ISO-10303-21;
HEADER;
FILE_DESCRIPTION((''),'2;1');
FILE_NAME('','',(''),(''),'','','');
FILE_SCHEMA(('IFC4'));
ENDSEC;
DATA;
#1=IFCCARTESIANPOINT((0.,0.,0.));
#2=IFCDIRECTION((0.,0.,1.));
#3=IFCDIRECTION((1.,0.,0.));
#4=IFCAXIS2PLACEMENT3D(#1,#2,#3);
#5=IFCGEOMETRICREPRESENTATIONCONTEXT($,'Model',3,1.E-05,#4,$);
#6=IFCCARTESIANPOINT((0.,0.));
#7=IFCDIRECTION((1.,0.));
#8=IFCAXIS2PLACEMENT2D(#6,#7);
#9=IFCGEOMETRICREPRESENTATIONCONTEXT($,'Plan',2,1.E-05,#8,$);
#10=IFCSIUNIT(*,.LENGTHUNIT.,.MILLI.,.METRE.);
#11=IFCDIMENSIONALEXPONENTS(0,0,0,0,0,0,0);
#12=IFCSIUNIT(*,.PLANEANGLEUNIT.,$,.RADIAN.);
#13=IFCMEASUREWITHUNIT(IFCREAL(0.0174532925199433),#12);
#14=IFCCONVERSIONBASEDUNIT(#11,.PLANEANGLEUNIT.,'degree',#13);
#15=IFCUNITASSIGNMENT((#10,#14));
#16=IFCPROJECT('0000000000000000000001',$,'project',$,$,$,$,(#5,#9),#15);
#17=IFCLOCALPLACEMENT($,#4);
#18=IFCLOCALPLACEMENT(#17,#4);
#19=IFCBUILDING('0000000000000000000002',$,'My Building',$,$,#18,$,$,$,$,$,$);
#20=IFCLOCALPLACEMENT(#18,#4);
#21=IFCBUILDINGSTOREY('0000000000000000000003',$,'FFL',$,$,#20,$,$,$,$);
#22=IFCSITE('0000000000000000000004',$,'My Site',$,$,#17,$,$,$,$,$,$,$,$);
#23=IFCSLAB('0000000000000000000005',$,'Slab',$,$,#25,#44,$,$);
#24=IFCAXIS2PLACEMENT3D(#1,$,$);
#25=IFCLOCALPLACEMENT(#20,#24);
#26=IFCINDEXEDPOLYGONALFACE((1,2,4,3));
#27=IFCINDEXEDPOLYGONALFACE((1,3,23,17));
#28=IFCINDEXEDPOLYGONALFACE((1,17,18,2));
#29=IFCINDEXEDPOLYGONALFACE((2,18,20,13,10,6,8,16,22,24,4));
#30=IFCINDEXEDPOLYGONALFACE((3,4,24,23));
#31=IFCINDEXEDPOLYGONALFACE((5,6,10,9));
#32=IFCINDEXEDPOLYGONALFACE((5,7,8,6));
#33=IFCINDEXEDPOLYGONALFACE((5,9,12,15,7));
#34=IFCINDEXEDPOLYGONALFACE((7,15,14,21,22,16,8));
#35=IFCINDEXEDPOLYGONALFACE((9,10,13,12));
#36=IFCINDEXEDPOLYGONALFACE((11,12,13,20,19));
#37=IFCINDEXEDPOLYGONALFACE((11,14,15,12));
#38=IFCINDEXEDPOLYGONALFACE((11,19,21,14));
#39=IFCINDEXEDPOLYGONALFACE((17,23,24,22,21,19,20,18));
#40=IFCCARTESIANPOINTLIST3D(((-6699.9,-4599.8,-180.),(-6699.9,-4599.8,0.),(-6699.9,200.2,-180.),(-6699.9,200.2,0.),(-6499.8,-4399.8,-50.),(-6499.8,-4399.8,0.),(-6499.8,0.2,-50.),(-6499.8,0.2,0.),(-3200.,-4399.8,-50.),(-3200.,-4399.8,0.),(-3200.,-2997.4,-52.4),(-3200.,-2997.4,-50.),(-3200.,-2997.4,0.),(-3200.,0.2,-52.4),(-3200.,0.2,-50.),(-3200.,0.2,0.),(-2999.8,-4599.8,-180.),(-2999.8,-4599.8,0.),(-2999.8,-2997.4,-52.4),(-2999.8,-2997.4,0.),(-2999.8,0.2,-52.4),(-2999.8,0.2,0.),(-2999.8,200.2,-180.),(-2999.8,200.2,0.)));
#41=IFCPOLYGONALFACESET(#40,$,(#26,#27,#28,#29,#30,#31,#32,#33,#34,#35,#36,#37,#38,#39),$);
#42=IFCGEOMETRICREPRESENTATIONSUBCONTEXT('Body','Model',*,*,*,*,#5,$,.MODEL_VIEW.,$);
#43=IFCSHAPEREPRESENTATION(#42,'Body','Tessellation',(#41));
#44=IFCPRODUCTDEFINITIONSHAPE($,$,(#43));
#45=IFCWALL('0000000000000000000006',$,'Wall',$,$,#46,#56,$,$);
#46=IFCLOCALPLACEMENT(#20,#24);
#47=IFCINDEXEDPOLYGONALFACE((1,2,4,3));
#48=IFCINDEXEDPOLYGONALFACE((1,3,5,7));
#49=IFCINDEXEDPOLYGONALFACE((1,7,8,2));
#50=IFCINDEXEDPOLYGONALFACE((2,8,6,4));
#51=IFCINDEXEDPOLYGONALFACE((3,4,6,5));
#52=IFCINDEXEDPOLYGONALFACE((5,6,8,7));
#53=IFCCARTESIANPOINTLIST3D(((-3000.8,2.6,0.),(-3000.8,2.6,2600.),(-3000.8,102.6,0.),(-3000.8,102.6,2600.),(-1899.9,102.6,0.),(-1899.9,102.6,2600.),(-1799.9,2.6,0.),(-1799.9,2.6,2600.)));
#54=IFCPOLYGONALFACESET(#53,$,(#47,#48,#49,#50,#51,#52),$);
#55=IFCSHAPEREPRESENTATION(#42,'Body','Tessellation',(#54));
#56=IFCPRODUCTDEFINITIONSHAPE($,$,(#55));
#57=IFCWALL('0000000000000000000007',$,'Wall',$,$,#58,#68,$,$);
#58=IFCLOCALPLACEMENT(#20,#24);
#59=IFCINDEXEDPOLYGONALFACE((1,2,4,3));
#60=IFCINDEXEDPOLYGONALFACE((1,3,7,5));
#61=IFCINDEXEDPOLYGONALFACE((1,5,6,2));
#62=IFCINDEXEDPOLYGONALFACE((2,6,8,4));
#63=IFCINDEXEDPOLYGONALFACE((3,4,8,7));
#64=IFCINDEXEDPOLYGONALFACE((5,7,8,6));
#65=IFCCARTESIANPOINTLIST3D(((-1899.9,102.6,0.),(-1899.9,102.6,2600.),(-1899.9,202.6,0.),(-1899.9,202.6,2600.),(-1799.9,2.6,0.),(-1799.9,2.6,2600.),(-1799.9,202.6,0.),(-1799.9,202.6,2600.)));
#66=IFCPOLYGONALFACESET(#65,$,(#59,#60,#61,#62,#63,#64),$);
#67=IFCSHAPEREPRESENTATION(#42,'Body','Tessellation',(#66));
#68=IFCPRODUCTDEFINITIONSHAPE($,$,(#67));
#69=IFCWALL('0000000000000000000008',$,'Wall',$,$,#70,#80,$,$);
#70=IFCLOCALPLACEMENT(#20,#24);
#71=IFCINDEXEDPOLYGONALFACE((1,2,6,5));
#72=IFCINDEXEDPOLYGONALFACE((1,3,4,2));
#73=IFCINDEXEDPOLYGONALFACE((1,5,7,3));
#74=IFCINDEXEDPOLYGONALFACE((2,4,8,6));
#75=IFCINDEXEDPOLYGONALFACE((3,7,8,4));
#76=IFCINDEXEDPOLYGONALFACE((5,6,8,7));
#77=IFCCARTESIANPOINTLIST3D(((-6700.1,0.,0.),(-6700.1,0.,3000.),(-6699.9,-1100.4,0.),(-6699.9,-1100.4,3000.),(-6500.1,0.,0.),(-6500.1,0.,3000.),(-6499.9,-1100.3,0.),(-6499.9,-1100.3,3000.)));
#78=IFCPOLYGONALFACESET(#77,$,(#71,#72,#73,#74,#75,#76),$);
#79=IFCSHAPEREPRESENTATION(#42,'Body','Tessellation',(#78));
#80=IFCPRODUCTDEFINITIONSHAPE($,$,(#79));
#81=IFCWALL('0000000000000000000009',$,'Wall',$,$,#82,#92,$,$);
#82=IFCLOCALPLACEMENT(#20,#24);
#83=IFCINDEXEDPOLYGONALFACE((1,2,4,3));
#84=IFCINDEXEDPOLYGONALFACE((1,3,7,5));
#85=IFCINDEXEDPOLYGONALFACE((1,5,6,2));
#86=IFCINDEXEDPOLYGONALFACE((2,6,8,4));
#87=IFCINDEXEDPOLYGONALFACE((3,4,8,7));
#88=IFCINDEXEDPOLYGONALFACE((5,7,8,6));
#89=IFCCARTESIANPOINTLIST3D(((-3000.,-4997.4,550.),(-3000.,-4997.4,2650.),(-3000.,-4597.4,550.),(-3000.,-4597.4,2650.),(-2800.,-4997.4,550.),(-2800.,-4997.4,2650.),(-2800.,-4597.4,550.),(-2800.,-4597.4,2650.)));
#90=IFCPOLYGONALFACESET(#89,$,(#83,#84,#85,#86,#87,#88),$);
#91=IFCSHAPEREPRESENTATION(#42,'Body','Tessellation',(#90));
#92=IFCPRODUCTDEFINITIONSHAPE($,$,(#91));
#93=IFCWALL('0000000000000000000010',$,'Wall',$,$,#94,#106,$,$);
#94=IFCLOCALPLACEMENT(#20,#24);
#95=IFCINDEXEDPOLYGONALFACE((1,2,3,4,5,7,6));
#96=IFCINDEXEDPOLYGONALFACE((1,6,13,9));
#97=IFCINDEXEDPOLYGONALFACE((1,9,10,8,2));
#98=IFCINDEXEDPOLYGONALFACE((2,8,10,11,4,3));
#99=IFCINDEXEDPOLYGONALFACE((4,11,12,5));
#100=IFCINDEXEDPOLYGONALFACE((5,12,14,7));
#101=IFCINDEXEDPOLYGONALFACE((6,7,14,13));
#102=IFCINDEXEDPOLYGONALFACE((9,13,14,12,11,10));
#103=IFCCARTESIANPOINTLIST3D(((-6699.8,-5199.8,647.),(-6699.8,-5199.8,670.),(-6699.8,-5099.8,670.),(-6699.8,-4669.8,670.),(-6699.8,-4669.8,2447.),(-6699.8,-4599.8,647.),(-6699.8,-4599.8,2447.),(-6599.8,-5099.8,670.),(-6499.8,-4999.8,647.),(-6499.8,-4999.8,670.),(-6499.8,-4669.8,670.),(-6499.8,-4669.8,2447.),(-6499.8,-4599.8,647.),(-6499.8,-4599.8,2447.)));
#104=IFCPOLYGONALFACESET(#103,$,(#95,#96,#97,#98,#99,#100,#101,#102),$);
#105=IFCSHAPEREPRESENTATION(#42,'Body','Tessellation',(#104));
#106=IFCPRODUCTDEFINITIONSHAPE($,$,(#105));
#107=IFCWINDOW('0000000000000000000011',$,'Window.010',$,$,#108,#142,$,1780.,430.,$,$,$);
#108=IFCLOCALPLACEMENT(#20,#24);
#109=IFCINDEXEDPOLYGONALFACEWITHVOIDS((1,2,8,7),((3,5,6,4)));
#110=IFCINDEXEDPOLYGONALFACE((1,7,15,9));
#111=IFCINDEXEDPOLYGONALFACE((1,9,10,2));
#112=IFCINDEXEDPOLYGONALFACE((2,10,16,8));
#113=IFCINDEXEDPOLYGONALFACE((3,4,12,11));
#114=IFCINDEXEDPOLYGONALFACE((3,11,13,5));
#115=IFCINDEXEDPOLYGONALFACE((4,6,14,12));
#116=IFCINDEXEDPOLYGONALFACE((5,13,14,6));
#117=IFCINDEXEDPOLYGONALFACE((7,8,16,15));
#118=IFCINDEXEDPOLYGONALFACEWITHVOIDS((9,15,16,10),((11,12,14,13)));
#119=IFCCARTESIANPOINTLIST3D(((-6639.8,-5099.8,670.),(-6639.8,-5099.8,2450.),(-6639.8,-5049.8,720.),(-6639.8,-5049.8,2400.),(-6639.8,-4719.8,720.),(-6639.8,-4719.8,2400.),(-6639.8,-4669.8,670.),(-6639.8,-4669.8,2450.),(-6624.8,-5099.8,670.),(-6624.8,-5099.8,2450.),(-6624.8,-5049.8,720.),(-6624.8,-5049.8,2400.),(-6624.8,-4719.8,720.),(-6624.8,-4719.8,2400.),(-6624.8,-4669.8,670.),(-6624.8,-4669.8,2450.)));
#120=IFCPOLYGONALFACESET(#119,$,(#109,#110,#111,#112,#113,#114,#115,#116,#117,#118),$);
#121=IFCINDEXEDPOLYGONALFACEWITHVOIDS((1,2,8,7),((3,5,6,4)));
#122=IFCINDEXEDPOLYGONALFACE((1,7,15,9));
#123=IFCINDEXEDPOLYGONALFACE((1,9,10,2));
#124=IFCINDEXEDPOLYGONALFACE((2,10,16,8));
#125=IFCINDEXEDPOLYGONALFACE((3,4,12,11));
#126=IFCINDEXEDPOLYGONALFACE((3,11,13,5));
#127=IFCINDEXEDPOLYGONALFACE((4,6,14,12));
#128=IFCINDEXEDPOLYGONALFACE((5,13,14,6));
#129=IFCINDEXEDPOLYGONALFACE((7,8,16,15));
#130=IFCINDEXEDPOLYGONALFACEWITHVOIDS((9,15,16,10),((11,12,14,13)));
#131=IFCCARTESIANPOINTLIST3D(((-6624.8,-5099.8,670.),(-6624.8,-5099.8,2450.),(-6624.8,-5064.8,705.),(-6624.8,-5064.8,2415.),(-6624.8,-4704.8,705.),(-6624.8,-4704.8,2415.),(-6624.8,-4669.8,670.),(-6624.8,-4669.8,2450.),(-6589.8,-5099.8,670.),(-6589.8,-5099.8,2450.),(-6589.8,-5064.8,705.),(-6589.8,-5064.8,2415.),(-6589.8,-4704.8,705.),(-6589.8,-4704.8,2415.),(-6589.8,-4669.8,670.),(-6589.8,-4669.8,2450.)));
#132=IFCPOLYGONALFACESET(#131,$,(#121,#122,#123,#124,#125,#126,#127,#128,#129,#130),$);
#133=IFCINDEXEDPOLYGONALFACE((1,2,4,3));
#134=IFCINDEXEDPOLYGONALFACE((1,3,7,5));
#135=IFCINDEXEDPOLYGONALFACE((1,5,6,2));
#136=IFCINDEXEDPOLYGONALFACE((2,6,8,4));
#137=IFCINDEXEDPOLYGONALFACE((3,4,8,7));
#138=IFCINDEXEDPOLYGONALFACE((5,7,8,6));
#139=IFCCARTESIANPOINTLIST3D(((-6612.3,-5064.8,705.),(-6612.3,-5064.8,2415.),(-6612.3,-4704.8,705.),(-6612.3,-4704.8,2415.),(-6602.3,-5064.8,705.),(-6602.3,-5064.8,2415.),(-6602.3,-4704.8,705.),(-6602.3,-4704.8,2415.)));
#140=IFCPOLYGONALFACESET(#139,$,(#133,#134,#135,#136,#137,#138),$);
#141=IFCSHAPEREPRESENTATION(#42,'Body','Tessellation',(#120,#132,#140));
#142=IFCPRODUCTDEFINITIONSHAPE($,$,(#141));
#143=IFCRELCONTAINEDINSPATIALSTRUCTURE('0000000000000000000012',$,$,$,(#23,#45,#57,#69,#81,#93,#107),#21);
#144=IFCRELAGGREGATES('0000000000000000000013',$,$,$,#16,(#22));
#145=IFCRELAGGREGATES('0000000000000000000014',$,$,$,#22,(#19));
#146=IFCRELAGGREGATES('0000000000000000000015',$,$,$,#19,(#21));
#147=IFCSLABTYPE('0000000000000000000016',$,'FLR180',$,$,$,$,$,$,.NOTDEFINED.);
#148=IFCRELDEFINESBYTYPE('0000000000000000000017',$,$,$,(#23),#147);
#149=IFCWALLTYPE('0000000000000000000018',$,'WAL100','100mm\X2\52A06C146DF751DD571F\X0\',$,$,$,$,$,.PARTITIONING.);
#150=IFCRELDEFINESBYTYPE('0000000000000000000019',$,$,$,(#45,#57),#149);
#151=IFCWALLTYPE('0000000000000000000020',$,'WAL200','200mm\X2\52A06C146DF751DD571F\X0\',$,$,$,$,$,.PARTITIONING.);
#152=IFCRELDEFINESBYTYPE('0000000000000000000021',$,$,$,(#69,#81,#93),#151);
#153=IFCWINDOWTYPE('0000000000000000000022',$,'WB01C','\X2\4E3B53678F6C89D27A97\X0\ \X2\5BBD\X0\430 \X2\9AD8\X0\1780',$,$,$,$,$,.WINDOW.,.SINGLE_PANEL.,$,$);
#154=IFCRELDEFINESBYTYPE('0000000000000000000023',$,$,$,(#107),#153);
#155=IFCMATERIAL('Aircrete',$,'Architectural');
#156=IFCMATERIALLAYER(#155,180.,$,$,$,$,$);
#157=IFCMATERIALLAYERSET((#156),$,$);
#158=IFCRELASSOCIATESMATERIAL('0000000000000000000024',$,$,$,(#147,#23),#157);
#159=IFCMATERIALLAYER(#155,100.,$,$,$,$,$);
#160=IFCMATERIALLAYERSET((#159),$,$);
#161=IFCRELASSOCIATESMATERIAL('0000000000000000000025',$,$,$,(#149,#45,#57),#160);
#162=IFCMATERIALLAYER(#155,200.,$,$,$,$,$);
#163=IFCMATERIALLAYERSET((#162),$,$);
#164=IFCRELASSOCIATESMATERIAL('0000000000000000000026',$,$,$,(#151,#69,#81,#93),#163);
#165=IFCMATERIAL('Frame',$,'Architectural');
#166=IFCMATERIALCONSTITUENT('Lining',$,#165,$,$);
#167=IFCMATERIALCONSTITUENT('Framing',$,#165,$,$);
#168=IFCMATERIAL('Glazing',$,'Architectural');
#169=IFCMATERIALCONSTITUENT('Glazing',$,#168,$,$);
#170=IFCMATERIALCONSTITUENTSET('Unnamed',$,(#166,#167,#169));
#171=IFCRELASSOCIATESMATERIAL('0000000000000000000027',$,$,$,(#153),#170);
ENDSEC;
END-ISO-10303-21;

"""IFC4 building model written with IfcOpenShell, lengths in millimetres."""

from ifc_helpers import new_model, entity, si_unit, converted_unit, frame, origin_with_axes, origin_2d_with_axis, place, context, subcontext, project, spatial, line, indexed_curve, outline, extrude, shape, source, transform, mapped, material, layer, layer_set, layer_usage, constituent, constituent_set, type_object, type_shapes, element, fill, save


model = new_model("IFC4")

# Units and contexts
model_context = context("Model", 3, precision=1e-05, world=origin_with_axes())
plan_context = context("Plan", 2, precision=1e-05, world=origin_2d_with_axis())
body_context_1 = subcontext(model_context, "Body", "Model", "MODEL_VIEW")
body_context_2 = subcontext(plan_context, "Body", "Plan", "PLAN_VIEW")
ifc_project = project(units=[si_unit("LENGTHUNIT", "METRE", prefix="MILLI"), converted_unit("PLANEANGLEUNIT", "degree", entity("IfcReal", 0.0174532925199433), si_unit("PLANEANGLEUNIT", "RADIAN"), dimensions=[0, 0, 0, 0, 0, 0, 0])], contexts=[model_context, plan_context])

# Site, building, storey
site_placement = place(None, origin_with_axes())
site = spatial("IfcSite", under=ifc_project, at=site_placement, Name="My Site")
building_placement = place(site_placement, origin_with_axes())
building = spatial("IfcBuilding", under=site, at=building_placement, Name="My Building")
storey_placement = place(building_placement, origin_with_axes())
storey = spatial("IfcBuildingStorey", under=building, at=storey_placement, Name="FFL")

# Slab, openings
ifc_material_1 = material(Name="Aircrete", Category="Architectural")
ifc_layer_1 = layer(ifc_material_1, 180.0)
ifc_layer_set_1 = layer_set([ifc_layer_1])
ifc_layer_usage_1 = layer_usage(ifc_layer_set_1, "AXIS3", "POSITIVE", 0.0)
slab_type = type_object("IfcSlabType", Name="FLR180", PredefinedType="NOTDEFINED", material=ifc_layer_set_1)
slab_1_placement = place(storey_placement, frame((-6499.8, -4399.8, -180.0), z_axis=(0.0, 0.0, 1.0), x_axis=(1.0, 0.0, 0.0)))
slab_1 = element("IfcSlab", 1, at=slab_1_placement, inside=storey, type_object=slab_type, material=ifc_layer_usage_1, Name="Slab", context=body_context_1, shape_type="SweptSolid", body=[
    extrude(outline(indexed_curve([(-200.1, -200.0), (3500.0, -200.0), (3500.0, 4600.0), (-200.1, 4600.0), (-200.1, -200.0)])), None, (0.0, 0.0, 1.0), 180.0),
])
opening_1_placement = place(slab_1_placement, frame((0.0, 0.0, 130.0), z_axis=(0.0, 0.0, 1.0), x_axis=(1.0, 0.0, 0.0)))
element("IfcOpeningElement", 2, at=opening_1_placement, cuts=slab_1, PredefinedType="OPENING", context=body_context_1, shape_type="SweptSolid", body=[
    extrude(outline(indexed_curve([(0.0, 4400.0), (3299.8, 4400.0), (3299.8, 0.0), (0.0, 0.0), (0.0, 4400.0)])), origin_with_axes(), (0.0, 0.0, 1.0), 100.0),
])
opening_2_placement = place(slab_1_placement, frame((3299.8, 1402.4, 127.6), z_axis=(0.0, 0.0, 1.0), x_axis=(1.0, 0.0, 0.0)))
element("IfcOpeningElement", 3, at=opening_2_placement, cuts=slab_1, PredefinedType="OPENING", context=body_context_1, shape_type="SweptSolid", body=[
    extrude(outline(indexed_curve([(0.0, 2997.6), (200.3, 2997.6), (200.3, 0.0), (0.0, 0.0), (0.0, 2997.6)])), origin_with_axes(), (0.0, 0.0, 1.0), 100.0),
])

# Walls
ifc_layer_2 = layer(ifc_material_1, 100.0)
ifc_layer_set_2 = layer_set([ifc_layer_2])
ifc_layer_usage_2 = layer_usage(ifc_layer_set_2, "AXIS2", "POSITIVE", 0.0)
wall_type_1 = type_object("IfcWallType", Name="WAL100", Description="100mm加气混凝土", PredefinedType="PARTITIONING", material=ifc_layer_set_2)
wall_1_placement = place(storey_placement, frame((-3000.8, 2.6, 0.0), z_axis=(0.0, 0.0, 1.0), x_axis=(1.0, 0.0, 0.0)))
element("IfcWall", 4, at=wall_1_placement, inside=storey, type_object=wall_type_1, material=ifc_layer_usage_2, Name="Wall", context=body_context_1, shape_type="SweptSolid", body=[
    extrude(outline(indexed_curve([(0.0, 0.0), (0.0, 100.0), (1100.9, 100.0), (1200.9, 0.0)], segments=[line(1, 2, 3, 4, 1)])), origin_with_axes(), (0.0, 0.0, 1.0), 2600.0),
])
ifc_layer_usage_3 = layer_usage(ifc_layer_set_2, "AXIS2", "POSITIVE", 0.0)
wall_2_placement = place(storey_placement, frame((-1799.9, 2.6, 0.0), z_axis=(0.0, 0.0, 1.0), x_axis=(0.0, 1.0, 0.0)))
element("IfcWall", 5, at=wall_2_placement, inside=storey, type_object=wall_type_1, material=ifc_layer_usage_3, Name="Wall", context=body_context_1, shape_type="SweptSolid", body=[
    extrude(outline(indexed_curve([(0.0, 0.0), (100.0, 100.0), (200.0, 100.0), (200.0, 0.0)], segments=[line(1, 2, 3, 4, 1)])), origin_with_axes(), (0.0, 0.0, 1.0), 2600.0),
])
ifc_layer_3 = layer(ifc_material_1, 200.0)
ifc_layer_set_3 = layer_set([ifc_layer_3])
ifc_layer_usage_4 = layer_usage(ifc_layer_set_3, "AXIS2", "NEGATIVE", 0.0)
wall_type_2 = type_object("IfcWallType", Name="WAL200", Description="200mm加气混凝土", PredefinedType="PARTITIONING", material=ifc_layer_set_3)
wall_3_placement = place(storey_placement, frame((-6699.9, -1100.4, 0.0), z_axis=(0.0, 0.0, 1.0), x_axis=(-0.000172, 1.0, 0.0)))
element("IfcWall", 6, at=wall_3_placement, inside=storey, type_object=wall_type_2, material=ifc_layer_usage_4, Name="Wall", context=body_context_1, shape_type="SweptSolid", body=[
    extrude(outline(indexed_curve([(0.0, -200.0), (0.0, 0.0), (1100.3, 0.0), (1100.3, -200.0)], segments=[line(1, 2, 3, 4, 1)])), origin_with_axes(), (0.0, 0.0, 1.0), 3000.0),
])
ifc_layer_usage_5 = layer_usage(ifc_layer_set_3, "AXIS2", "NEGATIVE", 0.0)
wall_4_placement = place(storey_placement, frame((-3000.0, -4997.4, 550.0), z_axis=(0.0, 0.0, 1.0), x_axis=(0.0, 1.0, 0.0)))
element("IfcWall", 7, at=wall_4_placement, inside=storey, type_object=wall_type_2, material=ifc_layer_usage_5, Name="Wall", context=body_context_1, shape_type="SweptSolid", body=[
    extrude(outline(indexed_curve([(0.0, -200.0), (0.0, 0.0), (400.0, 0.0), (400.0, -200.0)], segments=[line(1, 2, 3, 4, 1)])), origin_with_axes(), (0.0, 0.0, 1.0), 2100.0),
])

# Wall, openings, window
ifc_layer_usage_6 = layer_usage(ifc_layer_set_3, "AXIS2", "NEGATIVE", 0.0)
wall_5_placement = place(storey_placement, frame((-6499.8, -4599.8, 647.0), z_axis=(0.0, 0.0, 1.0), x_axis=(-0.000001, -1.0, 0.0)))
wall_5 = element("IfcWall", 8, at=wall_5_placement, inside=storey, type_object=wall_type_2, material=ifc_layer_usage_6, Name="Wall", context=body_context_1, shape_type="SweptSolid", body=[
    extrude(outline(indexed_curve([(0.0, -200.0), (0.0, 0.0), (400.0, 0.0), (600.0, -200.0)], segments=[line(1, 2, 3, 4, 1)])), origin_with_axes(), (0.0, 0.0, 1.0), 1800.0),
])
shared_shape_1 = source(origin_with_axes(), body_context_1, "Body", "SweptSolid", [
    extrude(outline(indexed_curve([(0.0, 0.0), (430.0, 0.0), (430.0, 1780.0), (0.0, 1780.0)], segments=[line(1, 2, 3, 4, 1)])), frame((0.0, -600.0, 0.0), z_axis=(0.0, -1.0, 0.0), x_axis=(1.0, 0.0, 0.0)), (0.0, 0.0, -1.0), 1200.0),
])
opening_3_placement = place(wall_5_placement, frame((70.0, -190.0, 23.0), z_axis=(0.0, 0.0, 1.0), x_axis=(1.0, 0.0, 0.0)))
opening_3 = element("IfcOpeningElement", 9, at=opening_3_placement, cuts=wall_5, PredefinedType="OPENING", context=body_context_1, shape_type="MappedRepresentation", body=[
    mapped(shared_shape_1, transform((0.0, 0.0, 0.0), x_axis=(1.0, 0.0, 0.0), y_axis=(0.0, 1.0, 0.0), z_axis=(0.0, 0.0, 1.0), scale=1.0)),
])
shared_shape_2 = source(origin_with_axes(), body_context_1, "Body", "SweptSolid", [
    extrude(outline(indexed_curve([(0.0, 0.0), (430.0, 0.0), (430.0, 1780.0), (0.0, 1780.0)], segments=[line(1, 2, 3, 4, 1)])), frame((0.0, -600.0, 0.0), z_axis=(0.0, -1.0, 0.0), x_axis=(1.0, 0.0, 0.0)), (0.0, 0.0, -1.0), 1200.0),
])
opening_4_placement = place(wall_5_placement, frame((500.0, -190.0, 23.0), z_axis=(0.0, 0.0, 1.0), x_axis=(1.0, 0.0, 0.0)))
element("IfcOpeningElement", 10, at=opening_4_placement, cuts=wall_5, PredefinedType="OPENING", context=body_context_1, shape_type="MappedRepresentation", body=[
    mapped(shared_shape_2, transform((0.0, 0.0, 0.0), x_axis=(1.0, 0.0, 0.0), y_axis=(0.0, 1.0, 0.0), z_axis=(0.0, 0.0, 1.0), scale=1.0)),
])
ifc_material_2 = material(Name="Frame", Category="Architectural")
ifc_constituent_1 = constituent(ifc_material_2, Name="Lining")
ifc_constituent_2 = constituent(ifc_material_2, Name="Framing")
ifc_material_3 = material(Name="Glazing", Category="Architectural")
ifc_constituent_3 = constituent(ifc_material_3, Name="Glazing")
ifc_constituent_set_1 = constituent_set(constituents=[ifc_constituent_1, ifc_constituent_2, ifc_constituent_3], Name="Unnamed")
window_type_1 = type_object("IfcWindowType", Name="WB01C", Description="主卧转角窗 宽430 高1780", PartitioningType="SINGLE_PANEL", PredefinedType="WINDOW", material=ifc_constituent_set_1)
shared_shape_3 = source(origin_with_axes(), body_context_1, "Body", "SweptSolid", [
    extrude(outline(indexed_curve([(0.0, 0.0), (430.0, 0.0), (430.0, 1780.0), (0.0, 1780.0)], segments=[line(1, 2, 3, 4, 1)]), holes=[indexed_curve([(50.0, 50.0), (380.0, 50.0), (380.0, 1730.0), (50.0, 1730.0)], segments=[line(1, 2, 3, 4, 1)])]), frame((0.0, 50.0, 0.0), z_axis=(0.0, -1.0, 0.0), x_axis=(1.0, 0.0, 0.0)), (0.0, 0.0, -1.0), 15.0),
    extrude(outline(indexed_curve([(0.0, 0.0), (430.0, 0.0), (430.0, 1780.0), (0.0, 1780.0)], segments=[line(1, 2, 3, 4, 1)]), holes=[indexed_curve([(35.0, 35.0), (395.0, 35.0), (395.0, 1745.0), (35.0, 1745.0)], segments=[line(1, 2, 3, 4, 1)])]), frame((0.0, 65.0, 0.0), z_axis=(0.0, -1.0, 0.0), x_axis=(1.0, 0.0, 0.0)), (0.0, 0.0, -1.0), 35.0),
    extrude(outline(indexed_curve([(35.0, 35.0), (395.0, 35.0), (395.0, 1745.0), (35.0, 1745.0)], segments=[line(1, 2, 3, 4, 1)])), frame((0.0, 77.5, 0.0), z_axis=(0.0, -1.0, 0.0), x_axis=(1.0, 0.0, 0.0)), (0.0, 0.0, -1.0), 10.0),
])
shared_shape_4 = source(origin_with_axes(), body_context_2, "Body", "Curve2D", [
    entity("IfcIndexedPolyCurve", entity("IfcCartesianPointList2D", [[50.0, 50.0], [380.0, 50.0]])),
    entity("IfcIndexedPolyCurve", entity("IfcCartesianPointList2D", [[0.0, 100.0], [0.0, 100.0], [0.0, 65.0], [50.0, 65.0], [50.0, 50.0], [0.0, 50.0]]), [entity("IfcLineIndex", [1, 2, 3, 4, 5, 6, 1])]),
    entity("IfcIndexedPolyCurve", entity("IfcCartesianPointList2D", [[430.0, 100.0], [430.0, 100.0], [430.0, 65.0], [380.0, 65.0], [380.0, 50.0], [430.0, 50.0]]), [entity("IfcLineIndex", [1, 2, 3, 4, 5, 6, 1])]),
    entity("IfcIndexedPolyCurve", entity("IfcCartesianPointList2D", [[0.0, 65.0], [35.0, 65.0], [35.0, 100.0], [0.0, 100.0]]), [entity("IfcLineIndex", [1, 2, 3, 4, 1])]),
    entity("IfcIndexedPolyCurve", entity("IfcCartesianPointList2D", [[430.0, 65.0], [395.0, 65.0], [395.0, 100.0], [430.0, 100.0]]), [entity("IfcLineIndex", [1, 2, 3, 4, 1])]),
    entity("IfcIndexedPolyCurve", entity("IfcCartesianPointList2D", [[35.0, 65.0], [395.0, 65.0]])),
    entity("IfcIndexedPolyCurve", entity("IfcCartesianPointList2D", [[35.0, 100.0], [395.0, 100.0]])),
    entity("IfcIndexedPolyCurve", entity("IfcCartesianPointList2D", [[35.0, 82.5], [395.0, 82.5]])),
])
type_shapes(window_type_1, [shared_shape_3, shared_shape_4])
window_1_placement = place(opening_3_placement, frame((0.0, 0.0, 0.0), z_axis=(0.0, 0.0, 1.0), x_axis=(1.0, 0.0, 0.0)))
window_1 = element("IfcWindow", 11, at=window_1_placement, inside=storey, type_object=window_type_1, Name="Window.010", OverallHeight=1780.0, OverallWidth=430.0, shapes=[
    shape(body_context_1, "Body", "MappedRepresentation", [mapped(shared_shape_3, transform((0.0, 0.0, 0.0), x_axis=(1.0, 0.0, 0.0), y_axis=(0.0, 1.0, 0.0), z_axis=(0.0, 0.0, 1.0), scale=1.0))]),
    shape(body_context_2, "Body", "MappedRepresentation", [mapped(shared_shape_4, transform((0.0, 0.0, 0.0), x_axis=(1.0, 0.0, 0.0), y_axis=(0.0, 1.0, 0.0), z_axis=(0.0, 0.0, 1.0), scale=1.0))]),
])
fill(opening_3, window_1)

save(model, "model.ifc")
